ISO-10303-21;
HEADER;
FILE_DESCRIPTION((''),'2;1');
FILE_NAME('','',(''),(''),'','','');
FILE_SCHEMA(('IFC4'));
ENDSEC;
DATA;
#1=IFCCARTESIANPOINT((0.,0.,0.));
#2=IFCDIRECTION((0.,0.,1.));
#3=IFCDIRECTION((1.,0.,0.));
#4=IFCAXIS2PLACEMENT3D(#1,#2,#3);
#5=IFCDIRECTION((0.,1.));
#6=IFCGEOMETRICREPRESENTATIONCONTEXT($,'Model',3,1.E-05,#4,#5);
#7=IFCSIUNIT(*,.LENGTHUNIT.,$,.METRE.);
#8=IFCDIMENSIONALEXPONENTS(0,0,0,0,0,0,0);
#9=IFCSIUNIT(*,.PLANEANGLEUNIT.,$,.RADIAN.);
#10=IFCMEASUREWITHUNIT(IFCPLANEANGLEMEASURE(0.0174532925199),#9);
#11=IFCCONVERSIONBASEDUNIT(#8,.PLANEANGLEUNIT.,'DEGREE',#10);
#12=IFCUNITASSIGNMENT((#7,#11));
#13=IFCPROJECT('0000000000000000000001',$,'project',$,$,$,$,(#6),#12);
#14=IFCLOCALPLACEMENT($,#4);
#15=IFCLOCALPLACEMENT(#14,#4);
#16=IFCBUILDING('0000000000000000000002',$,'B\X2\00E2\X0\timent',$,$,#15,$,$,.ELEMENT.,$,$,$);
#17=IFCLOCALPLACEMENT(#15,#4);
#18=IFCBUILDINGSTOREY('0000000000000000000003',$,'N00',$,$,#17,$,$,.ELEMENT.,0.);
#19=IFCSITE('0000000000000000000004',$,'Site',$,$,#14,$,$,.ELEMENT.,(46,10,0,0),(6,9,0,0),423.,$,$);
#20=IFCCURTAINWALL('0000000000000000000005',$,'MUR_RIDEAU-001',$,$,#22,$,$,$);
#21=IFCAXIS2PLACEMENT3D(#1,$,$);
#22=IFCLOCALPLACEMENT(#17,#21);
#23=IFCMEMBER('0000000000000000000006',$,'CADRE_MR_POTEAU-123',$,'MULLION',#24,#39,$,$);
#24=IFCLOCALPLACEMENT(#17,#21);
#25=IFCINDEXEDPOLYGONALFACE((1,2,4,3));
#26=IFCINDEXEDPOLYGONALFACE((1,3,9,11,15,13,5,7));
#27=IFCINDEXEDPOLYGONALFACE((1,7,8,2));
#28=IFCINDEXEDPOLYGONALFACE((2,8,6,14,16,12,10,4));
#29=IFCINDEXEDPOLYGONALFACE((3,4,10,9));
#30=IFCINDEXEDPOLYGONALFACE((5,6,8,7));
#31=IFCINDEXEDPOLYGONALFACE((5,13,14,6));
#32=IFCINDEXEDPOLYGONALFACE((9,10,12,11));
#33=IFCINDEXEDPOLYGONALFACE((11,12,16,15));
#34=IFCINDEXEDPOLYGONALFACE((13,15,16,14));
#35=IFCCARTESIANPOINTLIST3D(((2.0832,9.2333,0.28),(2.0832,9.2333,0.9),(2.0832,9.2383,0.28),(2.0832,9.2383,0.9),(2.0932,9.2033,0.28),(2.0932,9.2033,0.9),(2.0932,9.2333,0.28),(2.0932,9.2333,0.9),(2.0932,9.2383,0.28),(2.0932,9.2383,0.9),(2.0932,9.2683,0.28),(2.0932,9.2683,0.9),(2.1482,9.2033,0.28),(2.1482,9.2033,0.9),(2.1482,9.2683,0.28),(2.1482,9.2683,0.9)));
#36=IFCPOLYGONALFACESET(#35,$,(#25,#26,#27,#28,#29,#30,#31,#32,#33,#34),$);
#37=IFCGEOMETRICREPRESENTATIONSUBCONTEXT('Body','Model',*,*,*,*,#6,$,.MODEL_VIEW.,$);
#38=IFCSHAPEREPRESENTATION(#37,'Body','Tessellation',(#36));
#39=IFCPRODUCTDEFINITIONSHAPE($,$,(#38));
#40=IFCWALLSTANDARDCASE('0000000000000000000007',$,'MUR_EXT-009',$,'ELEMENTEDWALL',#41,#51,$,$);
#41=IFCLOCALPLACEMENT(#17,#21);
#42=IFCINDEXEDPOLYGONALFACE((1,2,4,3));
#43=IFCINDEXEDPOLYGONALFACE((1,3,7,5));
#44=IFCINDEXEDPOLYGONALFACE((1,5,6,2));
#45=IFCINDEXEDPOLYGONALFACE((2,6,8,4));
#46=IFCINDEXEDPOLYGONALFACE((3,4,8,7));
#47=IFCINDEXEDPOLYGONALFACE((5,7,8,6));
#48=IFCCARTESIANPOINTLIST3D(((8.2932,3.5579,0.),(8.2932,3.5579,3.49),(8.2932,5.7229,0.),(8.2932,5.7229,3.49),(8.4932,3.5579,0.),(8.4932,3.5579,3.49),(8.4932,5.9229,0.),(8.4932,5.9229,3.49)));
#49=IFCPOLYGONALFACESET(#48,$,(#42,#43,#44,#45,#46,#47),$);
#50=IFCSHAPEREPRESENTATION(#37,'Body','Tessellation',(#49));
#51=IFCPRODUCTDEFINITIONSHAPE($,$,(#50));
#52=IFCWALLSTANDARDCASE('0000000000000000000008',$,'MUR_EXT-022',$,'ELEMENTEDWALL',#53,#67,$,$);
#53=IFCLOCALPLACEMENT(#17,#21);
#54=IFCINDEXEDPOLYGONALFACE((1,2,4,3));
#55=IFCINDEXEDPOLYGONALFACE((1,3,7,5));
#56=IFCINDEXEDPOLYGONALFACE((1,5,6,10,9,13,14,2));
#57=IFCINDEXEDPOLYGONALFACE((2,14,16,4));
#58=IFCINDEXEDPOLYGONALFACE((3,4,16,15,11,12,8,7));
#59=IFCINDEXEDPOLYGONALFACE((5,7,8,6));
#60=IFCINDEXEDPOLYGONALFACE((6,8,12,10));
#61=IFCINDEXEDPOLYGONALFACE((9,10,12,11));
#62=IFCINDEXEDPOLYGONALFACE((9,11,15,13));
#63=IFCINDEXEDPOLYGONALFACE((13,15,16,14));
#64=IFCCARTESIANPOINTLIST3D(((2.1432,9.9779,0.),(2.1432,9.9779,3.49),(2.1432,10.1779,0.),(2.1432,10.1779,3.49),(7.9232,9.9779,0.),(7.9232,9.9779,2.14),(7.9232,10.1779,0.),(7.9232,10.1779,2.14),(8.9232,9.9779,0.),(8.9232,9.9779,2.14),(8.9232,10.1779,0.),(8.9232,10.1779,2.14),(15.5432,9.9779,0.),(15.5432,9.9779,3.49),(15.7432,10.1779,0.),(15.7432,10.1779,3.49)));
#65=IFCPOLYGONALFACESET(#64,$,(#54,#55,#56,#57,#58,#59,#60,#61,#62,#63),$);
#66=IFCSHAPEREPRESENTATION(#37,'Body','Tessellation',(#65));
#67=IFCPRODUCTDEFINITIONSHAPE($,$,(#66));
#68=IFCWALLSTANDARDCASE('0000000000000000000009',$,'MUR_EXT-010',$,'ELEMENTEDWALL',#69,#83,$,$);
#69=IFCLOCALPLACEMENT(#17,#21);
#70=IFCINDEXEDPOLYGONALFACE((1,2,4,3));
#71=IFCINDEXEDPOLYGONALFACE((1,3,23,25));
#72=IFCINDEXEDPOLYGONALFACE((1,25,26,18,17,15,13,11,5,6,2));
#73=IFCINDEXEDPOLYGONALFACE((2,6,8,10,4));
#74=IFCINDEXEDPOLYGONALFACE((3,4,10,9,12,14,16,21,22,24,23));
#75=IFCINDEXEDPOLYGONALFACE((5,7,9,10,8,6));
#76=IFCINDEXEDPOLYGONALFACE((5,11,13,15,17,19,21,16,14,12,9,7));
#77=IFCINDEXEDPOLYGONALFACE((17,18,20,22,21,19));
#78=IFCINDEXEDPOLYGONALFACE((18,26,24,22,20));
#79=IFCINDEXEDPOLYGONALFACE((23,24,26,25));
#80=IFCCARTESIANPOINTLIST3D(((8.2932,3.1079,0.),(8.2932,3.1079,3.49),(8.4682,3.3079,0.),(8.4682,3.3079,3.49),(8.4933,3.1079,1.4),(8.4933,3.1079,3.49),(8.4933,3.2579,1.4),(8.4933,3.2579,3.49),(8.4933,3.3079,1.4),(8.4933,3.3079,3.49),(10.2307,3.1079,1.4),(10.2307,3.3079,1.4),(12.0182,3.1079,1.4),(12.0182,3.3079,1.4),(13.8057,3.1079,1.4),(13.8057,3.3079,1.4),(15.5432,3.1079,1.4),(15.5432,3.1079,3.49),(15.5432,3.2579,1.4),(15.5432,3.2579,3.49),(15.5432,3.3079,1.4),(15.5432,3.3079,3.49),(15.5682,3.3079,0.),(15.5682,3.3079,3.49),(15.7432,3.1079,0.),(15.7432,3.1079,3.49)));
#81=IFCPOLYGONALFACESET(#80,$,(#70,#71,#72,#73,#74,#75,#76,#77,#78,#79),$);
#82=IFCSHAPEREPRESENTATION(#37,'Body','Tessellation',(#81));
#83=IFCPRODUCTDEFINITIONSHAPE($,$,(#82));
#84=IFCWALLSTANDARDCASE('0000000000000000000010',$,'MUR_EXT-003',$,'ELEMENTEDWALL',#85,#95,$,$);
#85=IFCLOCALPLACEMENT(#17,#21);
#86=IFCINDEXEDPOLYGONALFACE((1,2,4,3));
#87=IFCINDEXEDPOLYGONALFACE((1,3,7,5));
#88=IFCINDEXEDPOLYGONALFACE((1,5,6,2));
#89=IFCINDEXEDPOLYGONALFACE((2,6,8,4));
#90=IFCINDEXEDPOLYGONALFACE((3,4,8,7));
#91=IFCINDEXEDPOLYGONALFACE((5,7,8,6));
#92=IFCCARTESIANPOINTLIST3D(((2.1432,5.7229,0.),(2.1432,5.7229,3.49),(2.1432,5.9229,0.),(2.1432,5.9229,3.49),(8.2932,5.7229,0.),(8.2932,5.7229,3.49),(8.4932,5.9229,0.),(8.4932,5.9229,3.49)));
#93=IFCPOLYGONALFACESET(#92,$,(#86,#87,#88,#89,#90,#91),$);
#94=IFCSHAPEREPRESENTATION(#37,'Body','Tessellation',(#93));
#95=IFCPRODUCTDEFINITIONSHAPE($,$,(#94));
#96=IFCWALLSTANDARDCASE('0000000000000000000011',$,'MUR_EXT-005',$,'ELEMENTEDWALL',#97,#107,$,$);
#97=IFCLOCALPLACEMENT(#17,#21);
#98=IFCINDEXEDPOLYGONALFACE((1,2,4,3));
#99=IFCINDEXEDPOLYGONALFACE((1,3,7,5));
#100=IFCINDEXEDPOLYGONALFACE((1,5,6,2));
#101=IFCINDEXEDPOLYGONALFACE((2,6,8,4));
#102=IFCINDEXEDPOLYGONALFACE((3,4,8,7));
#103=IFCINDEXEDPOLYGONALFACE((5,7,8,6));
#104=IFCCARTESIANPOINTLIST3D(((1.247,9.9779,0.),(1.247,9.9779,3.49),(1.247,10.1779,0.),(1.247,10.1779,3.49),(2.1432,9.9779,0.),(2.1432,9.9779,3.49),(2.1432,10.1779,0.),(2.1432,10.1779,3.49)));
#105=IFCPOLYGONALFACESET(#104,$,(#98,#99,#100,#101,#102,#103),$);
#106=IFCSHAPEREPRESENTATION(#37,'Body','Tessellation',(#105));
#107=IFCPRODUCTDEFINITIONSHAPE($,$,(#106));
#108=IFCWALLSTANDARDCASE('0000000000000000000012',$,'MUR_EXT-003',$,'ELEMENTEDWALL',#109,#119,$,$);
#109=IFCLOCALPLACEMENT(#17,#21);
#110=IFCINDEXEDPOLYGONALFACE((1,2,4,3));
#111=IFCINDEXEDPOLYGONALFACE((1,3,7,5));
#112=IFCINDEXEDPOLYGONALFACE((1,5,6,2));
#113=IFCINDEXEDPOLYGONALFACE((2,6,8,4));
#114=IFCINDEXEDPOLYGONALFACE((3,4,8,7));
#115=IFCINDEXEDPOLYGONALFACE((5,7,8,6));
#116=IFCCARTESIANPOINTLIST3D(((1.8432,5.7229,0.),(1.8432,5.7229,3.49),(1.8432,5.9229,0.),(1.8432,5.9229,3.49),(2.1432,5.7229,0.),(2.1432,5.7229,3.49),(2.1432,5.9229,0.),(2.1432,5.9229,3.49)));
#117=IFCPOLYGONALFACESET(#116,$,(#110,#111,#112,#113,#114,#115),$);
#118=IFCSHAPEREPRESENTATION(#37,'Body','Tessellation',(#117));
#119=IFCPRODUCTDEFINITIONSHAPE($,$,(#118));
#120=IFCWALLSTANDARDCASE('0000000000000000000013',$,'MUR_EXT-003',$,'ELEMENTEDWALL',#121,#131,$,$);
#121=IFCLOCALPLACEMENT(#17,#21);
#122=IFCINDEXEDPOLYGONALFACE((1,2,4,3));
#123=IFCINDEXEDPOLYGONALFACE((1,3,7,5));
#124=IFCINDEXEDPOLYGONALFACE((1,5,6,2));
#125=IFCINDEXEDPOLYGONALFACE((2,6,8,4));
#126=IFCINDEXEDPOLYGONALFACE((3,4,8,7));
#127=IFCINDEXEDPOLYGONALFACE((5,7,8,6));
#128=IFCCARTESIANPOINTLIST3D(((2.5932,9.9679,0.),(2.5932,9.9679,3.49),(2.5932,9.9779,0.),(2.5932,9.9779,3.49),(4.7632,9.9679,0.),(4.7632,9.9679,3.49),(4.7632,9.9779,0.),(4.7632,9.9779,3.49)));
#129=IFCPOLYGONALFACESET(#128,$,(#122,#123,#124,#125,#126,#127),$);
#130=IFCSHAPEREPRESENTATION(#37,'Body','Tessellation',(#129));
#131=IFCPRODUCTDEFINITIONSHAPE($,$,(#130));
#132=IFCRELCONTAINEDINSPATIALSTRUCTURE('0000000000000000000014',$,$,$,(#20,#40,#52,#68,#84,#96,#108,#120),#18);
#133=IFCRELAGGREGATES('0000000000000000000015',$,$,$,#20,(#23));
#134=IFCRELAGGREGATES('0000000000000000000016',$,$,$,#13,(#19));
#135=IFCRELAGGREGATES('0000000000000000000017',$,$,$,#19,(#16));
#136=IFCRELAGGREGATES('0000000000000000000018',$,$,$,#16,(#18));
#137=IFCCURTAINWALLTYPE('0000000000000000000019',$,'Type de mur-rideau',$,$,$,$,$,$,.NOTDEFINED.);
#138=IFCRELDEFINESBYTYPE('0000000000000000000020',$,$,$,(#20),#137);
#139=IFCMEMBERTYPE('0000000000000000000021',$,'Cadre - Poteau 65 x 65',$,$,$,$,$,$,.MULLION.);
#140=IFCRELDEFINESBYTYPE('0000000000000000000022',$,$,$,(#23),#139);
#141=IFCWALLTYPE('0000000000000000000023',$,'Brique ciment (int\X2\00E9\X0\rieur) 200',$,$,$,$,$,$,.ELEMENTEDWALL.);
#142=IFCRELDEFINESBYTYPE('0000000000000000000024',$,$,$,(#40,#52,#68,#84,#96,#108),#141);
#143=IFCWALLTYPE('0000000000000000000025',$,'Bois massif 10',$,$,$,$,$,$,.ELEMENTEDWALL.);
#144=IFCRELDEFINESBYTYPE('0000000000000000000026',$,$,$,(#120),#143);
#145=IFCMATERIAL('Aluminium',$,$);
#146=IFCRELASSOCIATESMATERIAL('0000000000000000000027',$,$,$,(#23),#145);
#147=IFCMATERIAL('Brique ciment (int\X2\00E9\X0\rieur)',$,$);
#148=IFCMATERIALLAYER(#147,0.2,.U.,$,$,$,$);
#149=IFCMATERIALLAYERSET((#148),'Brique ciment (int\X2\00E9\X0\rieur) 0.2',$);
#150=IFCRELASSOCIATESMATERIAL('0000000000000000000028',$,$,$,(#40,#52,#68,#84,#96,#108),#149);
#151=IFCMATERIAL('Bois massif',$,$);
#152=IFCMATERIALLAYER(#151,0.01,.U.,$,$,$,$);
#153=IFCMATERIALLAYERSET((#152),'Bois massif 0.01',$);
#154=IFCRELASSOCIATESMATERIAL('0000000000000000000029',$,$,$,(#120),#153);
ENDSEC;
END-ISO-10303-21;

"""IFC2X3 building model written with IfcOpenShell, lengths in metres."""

from ifc_helpers import new_model, entity, si_unit, converted_unit, direction, frame, origin_with_axes, origin_2d_with_axis, place, context, subcontext, project, spatial, polyline, rectangle, outline, extrude, material, layer, layer_set, layer_usage, type_object, element, aggregate, save


model = new_model("IFC2X3")

# Units and contexts
model_context = context("Model", 3, precision=1e-05, world=origin_with_axes(), true_north=direction((0.0, 1.0)))
body_context = subcontext(model_context, "Body", "Model", "MODEL_VIEW")
ifc_project = project(units=[si_unit("LENGTHUNIT", "METRE"), converted_unit("PLANEANGLEUNIT", "DEGREE", entity("IfcPlaneAngleMeasure", 0.0174532925199), si_unit("PLANEANGLEUNIT", "RADIAN"), dimensions=[0, 0, 0, 0, 0, 0, 0])], contexts=[model_context])

# Site, building, storey
site_placement = place(None, origin_with_axes())
site = spatial("IfcSite", under=ifc_project, at=site_placement, Name="Site", CompositionType="ELEMENT", RefLatitude=(46, 10, 0, 0), RefLongitude=(6, 9, 0, 0), RefElevation=423.0)
building_placement = place(site_placement, origin_with_axes())
building = spatial("IfcBuilding", under=site, at=building_placement, Name="Bâtiment", CompositionType="ELEMENT")
storey_placement = place(building_placement, origin_with_axes())
storey = spatial("IfcBuildingStorey", under=building, at=storey_placement, Name="N00", CompositionType="ELEMENT", Elevation=0.0)

# Curtain wall, member
curtain_wall_type = type_object("IfcCurtainWallType", Name="Type de mur-rideau", PredefinedType="NOTDEFINED")
curtain_wall_placement = place(storey_placement, frame((2.0832, 6.4208, 0.0), z_axis=(0.0, 0.0, 1.0), x_axis=(1.0, 0.0, 0.0)))
curtain_wall = element("IfcCurtainWall", 1, at=curtain_wall_placement, inside=storey, type_object=curtain_wall_type, Name="MUR_RIDEAU-001")
ifc_material_1 = material(Name="Aluminium")
member_type_1 = type_object("IfcMemberType", Name="Cadre - Poteau 65 x 65", PredefinedType="MULLION")
member_1_placement = place(curtain_wall_placement, frame((0.0, 2.8149, 0.28), z_axis=(0.0, 0.0, 1.0), x_axis=(0.0, 1.0, 0.0)))
member_1 = element("IfcMember", 2, at=member_1_placement, type_object=member_type_1, material=ifc_material_1, Name="CADRE_MR_POTEAU-123", ObjectType="MULLION", context=body_context, shape_type="SweptSolid", body=[
    extrude(outline(polyline([(0.01, -0.0025), (0.01, -0.0325), (0.065, -0.0325), (0.065, 0.0325), (0.01, 0.0325), (0.01, 0.0025), (0.0, 0.0025), (0.0, -0.0025), (0.01, -0.0025)])), frame((0.0, 0.0, 0.0), z_axis=(0.0, 0.0, 1.0), x_axis=(0.0, -1.0, 0.0)), (0.0, 0.0, 1.0), 0.62),
])
aggregate(curtain_wall, [member_1])

# Wall
ifc_material_2 = material(Name="Brique ciment (intérieur)")
ifc_layer_1 = layer(ifc_material_2, 0.2, ventilated="UNKNOWN")
ifc_layer_set_1 = layer_set([ifc_layer_1], Name="Brique ciment (intérieur) 0.2")
ifc_layer_usage_1 = layer_usage(ifc_layer_set_1, "AXIS2", "POSITIVE", -0.2)
wall_type_1 = type_object("IfcWallType", Name="Brique ciment (intérieur) 200", PredefinedType="ELEMENTEDWALL")
wall_1_placement = place(storey_placement, frame((8.4932, 5.9229, 0.0), z_axis=(0.0, 0.0, 1.0), x_axis=(0.0, -1.0, 0.0)))
element("IfcWallStandardCase", 3, at=wall_1_placement, inside=storey, type_object=wall_type_1, material=ifc_layer_usage_1, Name="MUR_EXT-009", ObjectType="ELEMENTEDWALL", context=body_context, shape_type="SweptSolid", body=[
    extrude(outline(polyline([(0.2, -0.2), (2.365, -0.2), (2.365, 0.0), (0.0, 0.0), (0.2, -0.2)])), origin_with_axes(), (0.0, 0.0, 1.0), 3.49),
])

# Wall, opening
ifc_layer_usage_2 = layer_usage(ifc_layer_set_1, "AXIS2", "POSITIVE", -0.2)
wall_2_placement = place(storey_placement, frame((15.5432, 9.9779, 0.0), z_axis=(0.0, 0.0, 1.0), x_axis=(-1.0, 0.0, 0.0)))
wall_2 = element("IfcWallStandardCase", 4, at=wall_2_placement, inside=storey, type_object=wall_type_1, material=ifc_layer_usage_2, Name="MUR_EXT-022", ObjectType="ELEMENTEDWALL", context=body_context, shape_type="SweptSolid", body=[
    extrude(outline(polyline([(-0.2, -0.2), (13.4, -0.2), (13.4, 0.0), (0.0, 0.0), (-0.2, -0.2)])), origin_with_axes(), (0.0, 0.0, 1.0), 3.49),
])
opening_1_placement = place(wall_2_placement, frame((7.12, 0.0, 0.0), z_axis=(0.0, 0.0, 1.0), x_axis=(1.0, 0.0, 0.0)))
element("IfcOpeningElement", 5, at=opening_1_placement, cuts=wall_2, context=body_context, shape_type="SweptSolid", body=[
    extrude(rectangle(XDim=1.0, YDim=2.14, at=origin_2d_with_axis()), frame((0.0, 0.2, 1.07), z_axis=(0.0, 1.0, 0.0), x_axis=(-1.0, 0.0, 0.0)), (0.0, 0.0, -1.0), 0.6),
])

# Wall, openings
ifc_layer_usage_3 = layer_usage(ifc_layer_set_1, "AXIS2", "POSITIVE", -0.2)
wall_3_placement = place(storey_placement, frame((8.4682, 3.3079, 0.0), z_axis=(0.0, 0.0, 1.0), x_axis=(1.0, 0.0, 0.0)))
wall_3 = element("IfcWallStandardCase", 6, at=wall_3_placement, inside=storey, type_object=wall_type_1, material=ifc_layer_usage_3, Name="MUR_EXT-010", ObjectType="ELEMENTEDWALL", context=body_context, shape_type="SweptSolid", body=[
    extrude(outline(polyline([(-0.175, -0.2), (7.275, -0.2), (7.1, 0.0), (0.0, 0.0), (-0.175, -0.2)])), origin_with_axes(), (0.0, 0.0, 1.0), 3.49),
])
opening_2_placement = place(wall_3_placement, frame((0.8938, 0.0, 1.4), z_axis=(0.0, 0.0, 1.0), x_axis=(1.0, 0.0, 0.0)))
element("IfcOpeningElement", 7, at=opening_2_placement, cuts=wall_3, context=body_context, shape_type="SweptSolid", body=[
    extrude(rectangle(XDim=1.7374, YDim=2.09, at=origin_2d_with_axis()), frame((0.0, -0.05, 1.045), z_axis=(0.0, -1.0, 0.0), x_axis=(1.0, 0.0, 0.0)), (0.0, 0.0, 1.0), 0.35),
    extrude(rectangle(XDim=1.7374, YDim=2.09, at=origin_2d_with_axis()), frame((0.0, -0.05, 1.045), z_axis=(0.0, 1.0, 0.0), x_axis=(1.0, 0.0, 0.0)), (0.0, 0.0, 1.0), 0.25),
])
opening_3_placement = place(wall_3_placement, frame((2.6562, 0.0, 1.4), z_axis=(0.0, 0.0, 1.0), x_axis=(1.0, 0.0, 0.0)))
element("IfcOpeningElement", 8, at=opening_3_placement, cuts=wall_3, context=body_context, shape_type="SweptSolid", body=[
    extrude(rectangle(XDim=1.7875, YDim=2.09, at=origin_2d_with_axis()), frame((0.0, -0.05, 1.045), z_axis=(0.0, -1.0, 0.0), x_axis=(1.0, 0.0, 0.0)), (0.0, 0.0, 1.0), 0.35),
    extrude(rectangle(XDim=1.7875, YDim=2.09, at=origin_2d_with_axis()), frame((0.0, -0.05, 1.045), z_axis=(0.0, 1.0, 0.0), x_axis=(1.0, 0.0, 0.0)), (0.0, 0.0, 1.0), 0.25),
])
opening_4_placement = place(wall_3_placement, frame((4.4437, 0.0, 1.4), z_axis=(0.0, 0.0, 1.0), x_axis=(1.0, 0.0, 0.0)))
element("IfcOpeningElement", 9, at=opening_4_placement, cuts=wall_3, context=body_context, shape_type="SweptSolid", body=[
    extrude(rectangle(XDim=1.7875, YDim=2.09, at=origin_2d_with_axis()), frame((0.0, -0.05, 1.045), z_axis=(0.0, -1.0, 0.0), x_axis=(1.0, 0.0, 0.0)), (0.0, 0.0, 1.0), 0.35),
    extrude(rectangle(XDim=1.7875, YDim=2.09, at=origin_2d_with_axis()), frame((0.0, -0.05, 1.045), z_axis=(0.0, 1.0, 0.0), x_axis=(1.0, 0.0, 0.0)), (0.0, 0.0, 1.0), 0.25),
])
opening_5_placement = place(wall_3_placement, frame((6.2062, 0.0, 1.4), z_axis=(0.0, 0.0, 1.0), x_axis=(1.0, 0.0, 0.0)))
element("IfcOpeningElement", 10, at=opening_5_placement, cuts=wall_3, context=body_context, shape_type="SweptSolid", body=[
    extrude(rectangle(XDim=1.7375, YDim=2.09, at=origin_2d_with_axis()), frame((0.0, -0.05, 1.045), z_axis=(0.0, -1.0, 0.0), x_axis=(1.0, 0.0, 0.0)), (0.0, 0.0, 1.0), 0.35),
    extrude(rectangle(XDim=1.7375, YDim=2.09, at=origin_2d_with_axis()), frame((0.0, -0.05, 1.045), z_axis=(0.0, 1.0, 0.0), x_axis=(1.0, 0.0, 0.0)), (0.0, 0.0, 1.0), 0.25),
])

# Walls
ifc_layer_usage_4 = layer_usage(ifc_layer_set_1, "AXIS2", "POSITIVE", -0.2)
wall_4_placement = place(storey_placement, frame((2.1432, 5.9229, 0.0), z_axis=(0.0, 0.0, 1.0), x_axis=(1.0, 0.0, 0.0)))
element("IfcWallStandardCase", 11, at=wall_4_placement, inside=storey, type_object=wall_type_1, material=ifc_layer_usage_4, Name="MUR_EXT-003", ObjectType="ELEMENTEDWALL", context=body_context, shape_type="SweptSolid", body=[
    extrude(outline(polyline([(0.0, -0.2), (6.15, -0.2), (6.35, 0.0), (0.0, 0.0), (0.0, -0.2)])), origin_with_axes(), (0.0, 0.0, 1.0), 3.49),
])
ifc_layer_usage_5 = layer_usage(ifc_layer_set_1, "AXIS2", "POSITIVE", -0.2)
wall_5_placement = place(storey_placement, frame((2.1432, 9.9779, 0.0), z_axis=(0.0, 0.0, 1.0), x_axis=(-1.0, 0.0, 0.0)))
element("IfcWallStandardCase", 12, at=wall_5_placement, inside=storey, type_object=wall_type_1, material=ifc_layer_usage_5, Name="MUR_EXT-005", ObjectType="ELEMENTEDWALL", context=body_context, shape_type="SweptSolid", body=[
    extrude(outline(polyline([(0.0, -0.2), (0.8961, -0.2), (0.8961, 0.0), (0.0, 0.0), (0.0, -0.2)])), origin_with_axes(), (0.0, 0.0, 1.0), 3.49),
])
ifc_layer_usage_6 = layer_usage(ifc_layer_set_1, "AXIS2", "NEGATIVE", 0.2)
wall_6_placement = place(storey_placement, frame((2.1432, 5.9229, 0.0), z_axis=(0.0, 0.0, 1.0), x_axis=(-1.0, 0.0, 0.0)))
element("IfcWallStandardCase", 13, at=wall_6_placement, inside=storey, type_object=wall_type_1, material=ifc_layer_usage_6, Name="MUR_EXT-003", ObjectType="ELEMENTEDWALL", context=body_context, shape_type="SweptSolid", body=[
    extrude(outline(polyline([(0.0, 0.0), (0.3, 0.0), (0.3, 0.2), (0.0, 0.2), (0.0, 0.0)])), origin_with_axes(), (0.0, 0.0, 1.0), 3.49),
])
ifc_material_3 = material(Name="Bois massif")
ifc_layer_2 = layer(ifc_material_3, 0.01, ventilated="UNKNOWN")
ifc_layer_set_2 = layer_set([ifc_layer_2], Name="Bois massif 0.01")
ifc_layer_usage_7 = layer_usage(ifc_layer_set_2, "AXIS2", "POSITIVE", -0.01)
wall_type_2 = type_object("IfcWallType", Name="Bois massif 10", PredefinedType="ELEMENTEDWALL")
wall_7_placement = place(storey_placement, frame((2.5932, 9.9779, 0.0), z_axis=(0.0, 0.0, 1.0), x_axis=(1.0, 0.0, 0.0)))
element("IfcWallStandardCase", 14, at=wall_7_placement, inside=storey, type_object=wall_type_2, material=ifc_layer_usage_7, Name="MUR_EXT-003", ObjectType="ELEMENTEDWALL", context=body_context, shape_type="SweptSolid", body=[
    extrude(outline(polyline([(0.0, -0.01), (2.17, -0.01), (2.17, 0.0), (0.0, 0.0), (0.0, -0.01)])), origin_with_axes(), (0.0, 0.0, 1.0), 3.49),
])

save(model, "model.ifc")
